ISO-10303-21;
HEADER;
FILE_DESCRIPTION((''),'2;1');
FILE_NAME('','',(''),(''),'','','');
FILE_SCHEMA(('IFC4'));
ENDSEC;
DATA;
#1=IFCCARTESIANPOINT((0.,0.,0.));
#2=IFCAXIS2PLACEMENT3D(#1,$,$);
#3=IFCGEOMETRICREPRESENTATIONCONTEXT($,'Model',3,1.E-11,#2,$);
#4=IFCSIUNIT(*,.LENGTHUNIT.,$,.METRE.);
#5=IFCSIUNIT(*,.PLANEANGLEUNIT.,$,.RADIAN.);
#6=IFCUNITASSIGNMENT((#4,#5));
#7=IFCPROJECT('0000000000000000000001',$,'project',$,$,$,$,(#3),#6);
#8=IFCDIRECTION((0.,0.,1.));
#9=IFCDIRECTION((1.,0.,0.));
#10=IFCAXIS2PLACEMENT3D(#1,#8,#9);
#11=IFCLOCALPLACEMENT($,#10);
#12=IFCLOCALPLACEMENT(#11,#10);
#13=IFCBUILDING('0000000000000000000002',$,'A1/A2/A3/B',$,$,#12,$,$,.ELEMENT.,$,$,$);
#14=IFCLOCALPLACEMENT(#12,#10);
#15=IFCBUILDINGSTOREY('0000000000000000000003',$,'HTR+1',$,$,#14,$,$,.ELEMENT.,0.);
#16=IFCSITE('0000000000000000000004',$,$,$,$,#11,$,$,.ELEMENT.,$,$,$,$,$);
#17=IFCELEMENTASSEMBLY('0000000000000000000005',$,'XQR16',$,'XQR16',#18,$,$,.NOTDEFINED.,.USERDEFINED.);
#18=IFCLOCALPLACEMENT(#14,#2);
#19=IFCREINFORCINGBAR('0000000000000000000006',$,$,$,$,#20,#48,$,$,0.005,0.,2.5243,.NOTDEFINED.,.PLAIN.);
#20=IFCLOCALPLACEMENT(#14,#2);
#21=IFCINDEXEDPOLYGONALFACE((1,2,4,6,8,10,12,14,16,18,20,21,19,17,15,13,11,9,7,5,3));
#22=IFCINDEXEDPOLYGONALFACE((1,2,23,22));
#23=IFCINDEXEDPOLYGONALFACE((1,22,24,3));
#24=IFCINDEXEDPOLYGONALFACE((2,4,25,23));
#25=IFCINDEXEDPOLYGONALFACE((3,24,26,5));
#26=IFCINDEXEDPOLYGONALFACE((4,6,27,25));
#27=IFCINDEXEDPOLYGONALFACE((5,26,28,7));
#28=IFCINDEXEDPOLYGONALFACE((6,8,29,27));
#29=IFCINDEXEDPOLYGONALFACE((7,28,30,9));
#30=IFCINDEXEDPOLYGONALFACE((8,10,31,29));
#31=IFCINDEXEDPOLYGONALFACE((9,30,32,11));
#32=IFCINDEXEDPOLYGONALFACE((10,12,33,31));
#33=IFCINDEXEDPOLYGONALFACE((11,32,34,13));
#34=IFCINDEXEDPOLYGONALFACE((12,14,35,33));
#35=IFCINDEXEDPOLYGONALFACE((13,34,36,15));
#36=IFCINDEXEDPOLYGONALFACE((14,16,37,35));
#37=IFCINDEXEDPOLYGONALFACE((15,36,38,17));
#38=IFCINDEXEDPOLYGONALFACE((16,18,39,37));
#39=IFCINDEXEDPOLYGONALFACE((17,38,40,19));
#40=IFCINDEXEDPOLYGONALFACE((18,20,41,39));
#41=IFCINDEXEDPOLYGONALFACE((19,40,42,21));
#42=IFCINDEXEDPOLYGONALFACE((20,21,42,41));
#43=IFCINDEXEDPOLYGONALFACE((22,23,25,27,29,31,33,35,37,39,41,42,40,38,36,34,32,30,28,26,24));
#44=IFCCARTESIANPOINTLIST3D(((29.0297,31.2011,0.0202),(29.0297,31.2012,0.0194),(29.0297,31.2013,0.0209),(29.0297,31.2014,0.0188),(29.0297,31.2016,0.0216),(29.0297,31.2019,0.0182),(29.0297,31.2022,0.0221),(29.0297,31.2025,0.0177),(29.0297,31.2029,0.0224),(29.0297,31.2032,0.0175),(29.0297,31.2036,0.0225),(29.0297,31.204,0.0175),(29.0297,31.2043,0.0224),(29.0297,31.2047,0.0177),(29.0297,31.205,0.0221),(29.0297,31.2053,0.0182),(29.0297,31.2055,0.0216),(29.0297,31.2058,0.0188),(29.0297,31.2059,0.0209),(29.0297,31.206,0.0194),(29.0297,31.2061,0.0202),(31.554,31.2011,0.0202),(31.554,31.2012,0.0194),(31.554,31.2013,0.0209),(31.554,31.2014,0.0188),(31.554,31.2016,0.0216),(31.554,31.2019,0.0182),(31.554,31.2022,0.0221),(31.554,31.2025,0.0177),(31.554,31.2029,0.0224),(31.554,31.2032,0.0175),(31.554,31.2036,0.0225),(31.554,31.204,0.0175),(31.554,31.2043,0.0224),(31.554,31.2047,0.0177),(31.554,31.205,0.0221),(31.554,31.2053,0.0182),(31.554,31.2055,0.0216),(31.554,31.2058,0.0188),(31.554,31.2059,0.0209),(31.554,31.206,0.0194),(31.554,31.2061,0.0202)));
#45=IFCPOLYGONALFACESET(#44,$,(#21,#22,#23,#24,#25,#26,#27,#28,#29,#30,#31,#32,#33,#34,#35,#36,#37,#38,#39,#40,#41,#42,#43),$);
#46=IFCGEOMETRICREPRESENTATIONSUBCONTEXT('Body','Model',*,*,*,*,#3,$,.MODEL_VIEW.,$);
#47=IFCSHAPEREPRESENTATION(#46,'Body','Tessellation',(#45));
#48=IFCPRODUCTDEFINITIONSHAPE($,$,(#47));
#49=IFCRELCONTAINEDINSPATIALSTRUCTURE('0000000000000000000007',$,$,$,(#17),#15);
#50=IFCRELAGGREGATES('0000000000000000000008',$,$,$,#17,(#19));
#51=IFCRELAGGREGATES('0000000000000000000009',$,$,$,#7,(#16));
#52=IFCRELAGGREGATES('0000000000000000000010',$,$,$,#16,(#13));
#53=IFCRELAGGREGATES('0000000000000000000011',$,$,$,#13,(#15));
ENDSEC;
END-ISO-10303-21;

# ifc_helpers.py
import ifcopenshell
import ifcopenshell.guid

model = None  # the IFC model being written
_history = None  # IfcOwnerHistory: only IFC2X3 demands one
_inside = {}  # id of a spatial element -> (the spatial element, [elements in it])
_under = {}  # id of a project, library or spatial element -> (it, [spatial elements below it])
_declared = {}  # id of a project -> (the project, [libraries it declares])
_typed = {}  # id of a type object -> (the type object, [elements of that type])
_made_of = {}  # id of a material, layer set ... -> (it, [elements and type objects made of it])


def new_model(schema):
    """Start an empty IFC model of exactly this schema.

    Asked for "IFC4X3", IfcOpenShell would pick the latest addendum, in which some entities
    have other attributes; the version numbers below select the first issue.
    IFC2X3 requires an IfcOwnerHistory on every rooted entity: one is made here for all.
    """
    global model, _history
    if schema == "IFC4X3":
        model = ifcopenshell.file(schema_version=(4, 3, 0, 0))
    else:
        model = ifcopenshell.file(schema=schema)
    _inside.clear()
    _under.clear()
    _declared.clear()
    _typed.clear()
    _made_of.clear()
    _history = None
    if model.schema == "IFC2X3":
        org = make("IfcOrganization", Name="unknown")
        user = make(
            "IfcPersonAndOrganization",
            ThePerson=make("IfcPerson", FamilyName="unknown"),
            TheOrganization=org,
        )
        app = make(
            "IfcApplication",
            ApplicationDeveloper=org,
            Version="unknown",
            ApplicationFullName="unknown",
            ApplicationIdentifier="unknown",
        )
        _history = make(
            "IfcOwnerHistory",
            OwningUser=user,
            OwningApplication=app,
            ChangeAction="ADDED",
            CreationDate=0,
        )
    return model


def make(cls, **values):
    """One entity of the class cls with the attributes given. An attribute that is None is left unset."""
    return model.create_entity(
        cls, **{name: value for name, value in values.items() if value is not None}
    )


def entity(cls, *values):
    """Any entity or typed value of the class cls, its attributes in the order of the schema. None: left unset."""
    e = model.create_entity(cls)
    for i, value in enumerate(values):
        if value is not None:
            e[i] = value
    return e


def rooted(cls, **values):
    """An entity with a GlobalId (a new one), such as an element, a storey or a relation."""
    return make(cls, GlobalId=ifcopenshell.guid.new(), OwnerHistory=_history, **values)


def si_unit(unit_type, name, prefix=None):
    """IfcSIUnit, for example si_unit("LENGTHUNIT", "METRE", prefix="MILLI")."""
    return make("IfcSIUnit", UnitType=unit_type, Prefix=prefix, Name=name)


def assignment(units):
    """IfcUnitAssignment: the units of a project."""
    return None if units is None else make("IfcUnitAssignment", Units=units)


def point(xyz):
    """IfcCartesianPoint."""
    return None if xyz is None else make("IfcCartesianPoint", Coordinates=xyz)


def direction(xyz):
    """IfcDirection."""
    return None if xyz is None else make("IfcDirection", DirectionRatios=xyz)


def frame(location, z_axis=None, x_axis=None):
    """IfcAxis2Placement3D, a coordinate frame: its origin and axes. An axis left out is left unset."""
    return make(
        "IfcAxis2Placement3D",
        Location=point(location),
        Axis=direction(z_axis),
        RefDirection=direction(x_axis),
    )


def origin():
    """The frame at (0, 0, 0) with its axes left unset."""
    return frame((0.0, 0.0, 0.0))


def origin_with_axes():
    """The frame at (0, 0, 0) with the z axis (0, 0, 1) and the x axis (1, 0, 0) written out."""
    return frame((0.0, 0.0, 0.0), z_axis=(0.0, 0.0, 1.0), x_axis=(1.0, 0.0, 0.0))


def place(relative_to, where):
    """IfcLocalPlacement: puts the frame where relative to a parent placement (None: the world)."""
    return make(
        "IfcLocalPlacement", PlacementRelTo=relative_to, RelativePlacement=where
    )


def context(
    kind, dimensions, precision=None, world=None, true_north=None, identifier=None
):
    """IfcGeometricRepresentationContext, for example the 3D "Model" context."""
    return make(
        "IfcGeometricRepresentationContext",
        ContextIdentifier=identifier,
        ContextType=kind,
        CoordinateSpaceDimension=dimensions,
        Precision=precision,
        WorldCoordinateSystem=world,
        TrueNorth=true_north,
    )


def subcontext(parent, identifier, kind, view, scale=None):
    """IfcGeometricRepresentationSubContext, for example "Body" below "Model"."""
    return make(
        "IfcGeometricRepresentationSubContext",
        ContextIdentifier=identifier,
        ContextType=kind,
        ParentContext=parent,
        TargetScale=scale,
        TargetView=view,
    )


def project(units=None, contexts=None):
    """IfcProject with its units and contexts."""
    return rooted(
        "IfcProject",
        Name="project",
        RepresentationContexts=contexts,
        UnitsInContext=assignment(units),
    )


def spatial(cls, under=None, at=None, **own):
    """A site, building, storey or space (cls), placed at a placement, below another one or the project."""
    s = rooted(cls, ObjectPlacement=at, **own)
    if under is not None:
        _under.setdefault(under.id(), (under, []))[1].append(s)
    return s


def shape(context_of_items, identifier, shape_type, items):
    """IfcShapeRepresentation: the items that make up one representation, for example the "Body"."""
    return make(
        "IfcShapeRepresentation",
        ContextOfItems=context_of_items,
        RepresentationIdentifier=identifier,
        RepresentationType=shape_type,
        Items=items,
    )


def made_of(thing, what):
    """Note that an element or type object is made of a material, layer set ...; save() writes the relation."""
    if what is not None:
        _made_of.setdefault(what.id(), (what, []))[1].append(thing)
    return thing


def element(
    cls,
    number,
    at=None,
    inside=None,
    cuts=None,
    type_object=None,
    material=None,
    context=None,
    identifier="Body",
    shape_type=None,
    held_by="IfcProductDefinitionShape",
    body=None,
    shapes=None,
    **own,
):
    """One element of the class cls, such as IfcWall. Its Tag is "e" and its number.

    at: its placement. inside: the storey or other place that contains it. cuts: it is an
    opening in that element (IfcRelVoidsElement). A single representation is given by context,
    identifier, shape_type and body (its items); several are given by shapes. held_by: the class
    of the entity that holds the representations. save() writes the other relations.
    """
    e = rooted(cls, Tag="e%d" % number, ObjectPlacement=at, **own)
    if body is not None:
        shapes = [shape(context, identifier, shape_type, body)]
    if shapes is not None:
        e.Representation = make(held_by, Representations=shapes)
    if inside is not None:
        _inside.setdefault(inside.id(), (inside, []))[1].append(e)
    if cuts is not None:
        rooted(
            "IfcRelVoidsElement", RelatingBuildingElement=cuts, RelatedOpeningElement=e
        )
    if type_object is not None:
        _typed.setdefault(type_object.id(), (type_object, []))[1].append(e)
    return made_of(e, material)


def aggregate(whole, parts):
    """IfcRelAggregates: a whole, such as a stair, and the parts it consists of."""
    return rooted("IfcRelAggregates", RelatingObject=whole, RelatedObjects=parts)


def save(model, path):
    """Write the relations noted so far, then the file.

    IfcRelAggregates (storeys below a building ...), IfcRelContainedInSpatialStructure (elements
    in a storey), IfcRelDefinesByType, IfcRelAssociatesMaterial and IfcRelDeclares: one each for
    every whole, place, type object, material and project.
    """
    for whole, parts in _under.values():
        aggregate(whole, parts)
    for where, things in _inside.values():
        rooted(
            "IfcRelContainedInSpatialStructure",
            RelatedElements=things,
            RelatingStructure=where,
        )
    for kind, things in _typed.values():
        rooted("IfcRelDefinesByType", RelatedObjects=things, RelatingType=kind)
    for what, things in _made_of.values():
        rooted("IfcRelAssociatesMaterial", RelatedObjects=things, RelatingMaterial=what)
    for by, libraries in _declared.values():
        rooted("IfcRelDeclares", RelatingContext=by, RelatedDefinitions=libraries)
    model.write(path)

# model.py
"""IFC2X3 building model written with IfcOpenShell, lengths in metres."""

from ifc_helpers import new_model, entity, si_unit, origin, origin_with_axes, place, context, subcontext, project, spatial, shape, element, aggregate, save


model = new_model("IFC2X3")

# Units and contexts
model_context = context("Model", 3, precision=1e-11, world=origin())
body_context = subcontext(model_context, "Body", "Model", "MODEL_VIEW")
ifc_project = project(units=[si_unit("LENGTHUNIT", "METRE"), si_unit("PLANEANGLEUNIT", "RADIAN")], contexts=[model_context])

# Site, building, storey
site_placement = place(None, origin_with_axes())
site = spatial("IfcSite", under=ifc_project, at=site_placement, CompositionType="ELEMENT")
building_placement = place(site_placement, origin_with_axes())
building = spatial("IfcBuilding", under=site, at=building_placement, Name="A1/A2/A3/B", CompositionType="ELEMENT")
storey_placement = place(building_placement, origin_with_axes())
storey = spatial("IfcBuildingStorey", under=building, at=storey_placement, Name="HTR+1", CompositionType="ELEMENT", Elevation=0.0)

# Element assembly, reinforcing bar
assembly_1_placement = place(storey_placement, origin_with_axes())
assembly_1 = element("IfcElementAssembly", 1, at=assembly_1_placement, inside=storey, Name="XQR16", ObjectType="XQR16", AssemblyPlace="NOTDEFINED", PredefinedType="USERDEFINED")
reinforcing_bar_1_placement = place(assembly_1_placement, origin_with_axes())
reinforcing_bar_1 = element("IfcReinforcingBar", 2, at=reinforcing_bar_1_placement, BarLength=2.5243, BarRole="NOTDEFINED", BarSurface="PLAIN", CrossSectionArea=0.0, NominalDiameter=0.005, shapes=[
    shape(body_context, "Body", "AdvancedSweptSolid", [entity("IfcSweptDiskSolid", entity("IfcPolyline", [entity("IfcCartesianPoint", [29.0297, 31.2036, 0.02]), entity("IfcCartesianPoint", [31.554, 31.2036, 0.02])]), 0.0025, None, 0.0, 2.5243)]),
    shape(body_context, "Body", "AdvancedSweptSolid", [entity("IfcSweptDiskSolid", entity("IfcPolyline", [entity("IfcCartesianPoint", [29.0297, 31.2036, 0.02]), entity("IfcCartesianPoint", [31.554, 31.2036, 0.02])]), 0.0025, None, 0.0, 2.5243)]),
])
aggregate(assembly_1, [reinforcing_bar_1])

save(model, "model.ifc")
